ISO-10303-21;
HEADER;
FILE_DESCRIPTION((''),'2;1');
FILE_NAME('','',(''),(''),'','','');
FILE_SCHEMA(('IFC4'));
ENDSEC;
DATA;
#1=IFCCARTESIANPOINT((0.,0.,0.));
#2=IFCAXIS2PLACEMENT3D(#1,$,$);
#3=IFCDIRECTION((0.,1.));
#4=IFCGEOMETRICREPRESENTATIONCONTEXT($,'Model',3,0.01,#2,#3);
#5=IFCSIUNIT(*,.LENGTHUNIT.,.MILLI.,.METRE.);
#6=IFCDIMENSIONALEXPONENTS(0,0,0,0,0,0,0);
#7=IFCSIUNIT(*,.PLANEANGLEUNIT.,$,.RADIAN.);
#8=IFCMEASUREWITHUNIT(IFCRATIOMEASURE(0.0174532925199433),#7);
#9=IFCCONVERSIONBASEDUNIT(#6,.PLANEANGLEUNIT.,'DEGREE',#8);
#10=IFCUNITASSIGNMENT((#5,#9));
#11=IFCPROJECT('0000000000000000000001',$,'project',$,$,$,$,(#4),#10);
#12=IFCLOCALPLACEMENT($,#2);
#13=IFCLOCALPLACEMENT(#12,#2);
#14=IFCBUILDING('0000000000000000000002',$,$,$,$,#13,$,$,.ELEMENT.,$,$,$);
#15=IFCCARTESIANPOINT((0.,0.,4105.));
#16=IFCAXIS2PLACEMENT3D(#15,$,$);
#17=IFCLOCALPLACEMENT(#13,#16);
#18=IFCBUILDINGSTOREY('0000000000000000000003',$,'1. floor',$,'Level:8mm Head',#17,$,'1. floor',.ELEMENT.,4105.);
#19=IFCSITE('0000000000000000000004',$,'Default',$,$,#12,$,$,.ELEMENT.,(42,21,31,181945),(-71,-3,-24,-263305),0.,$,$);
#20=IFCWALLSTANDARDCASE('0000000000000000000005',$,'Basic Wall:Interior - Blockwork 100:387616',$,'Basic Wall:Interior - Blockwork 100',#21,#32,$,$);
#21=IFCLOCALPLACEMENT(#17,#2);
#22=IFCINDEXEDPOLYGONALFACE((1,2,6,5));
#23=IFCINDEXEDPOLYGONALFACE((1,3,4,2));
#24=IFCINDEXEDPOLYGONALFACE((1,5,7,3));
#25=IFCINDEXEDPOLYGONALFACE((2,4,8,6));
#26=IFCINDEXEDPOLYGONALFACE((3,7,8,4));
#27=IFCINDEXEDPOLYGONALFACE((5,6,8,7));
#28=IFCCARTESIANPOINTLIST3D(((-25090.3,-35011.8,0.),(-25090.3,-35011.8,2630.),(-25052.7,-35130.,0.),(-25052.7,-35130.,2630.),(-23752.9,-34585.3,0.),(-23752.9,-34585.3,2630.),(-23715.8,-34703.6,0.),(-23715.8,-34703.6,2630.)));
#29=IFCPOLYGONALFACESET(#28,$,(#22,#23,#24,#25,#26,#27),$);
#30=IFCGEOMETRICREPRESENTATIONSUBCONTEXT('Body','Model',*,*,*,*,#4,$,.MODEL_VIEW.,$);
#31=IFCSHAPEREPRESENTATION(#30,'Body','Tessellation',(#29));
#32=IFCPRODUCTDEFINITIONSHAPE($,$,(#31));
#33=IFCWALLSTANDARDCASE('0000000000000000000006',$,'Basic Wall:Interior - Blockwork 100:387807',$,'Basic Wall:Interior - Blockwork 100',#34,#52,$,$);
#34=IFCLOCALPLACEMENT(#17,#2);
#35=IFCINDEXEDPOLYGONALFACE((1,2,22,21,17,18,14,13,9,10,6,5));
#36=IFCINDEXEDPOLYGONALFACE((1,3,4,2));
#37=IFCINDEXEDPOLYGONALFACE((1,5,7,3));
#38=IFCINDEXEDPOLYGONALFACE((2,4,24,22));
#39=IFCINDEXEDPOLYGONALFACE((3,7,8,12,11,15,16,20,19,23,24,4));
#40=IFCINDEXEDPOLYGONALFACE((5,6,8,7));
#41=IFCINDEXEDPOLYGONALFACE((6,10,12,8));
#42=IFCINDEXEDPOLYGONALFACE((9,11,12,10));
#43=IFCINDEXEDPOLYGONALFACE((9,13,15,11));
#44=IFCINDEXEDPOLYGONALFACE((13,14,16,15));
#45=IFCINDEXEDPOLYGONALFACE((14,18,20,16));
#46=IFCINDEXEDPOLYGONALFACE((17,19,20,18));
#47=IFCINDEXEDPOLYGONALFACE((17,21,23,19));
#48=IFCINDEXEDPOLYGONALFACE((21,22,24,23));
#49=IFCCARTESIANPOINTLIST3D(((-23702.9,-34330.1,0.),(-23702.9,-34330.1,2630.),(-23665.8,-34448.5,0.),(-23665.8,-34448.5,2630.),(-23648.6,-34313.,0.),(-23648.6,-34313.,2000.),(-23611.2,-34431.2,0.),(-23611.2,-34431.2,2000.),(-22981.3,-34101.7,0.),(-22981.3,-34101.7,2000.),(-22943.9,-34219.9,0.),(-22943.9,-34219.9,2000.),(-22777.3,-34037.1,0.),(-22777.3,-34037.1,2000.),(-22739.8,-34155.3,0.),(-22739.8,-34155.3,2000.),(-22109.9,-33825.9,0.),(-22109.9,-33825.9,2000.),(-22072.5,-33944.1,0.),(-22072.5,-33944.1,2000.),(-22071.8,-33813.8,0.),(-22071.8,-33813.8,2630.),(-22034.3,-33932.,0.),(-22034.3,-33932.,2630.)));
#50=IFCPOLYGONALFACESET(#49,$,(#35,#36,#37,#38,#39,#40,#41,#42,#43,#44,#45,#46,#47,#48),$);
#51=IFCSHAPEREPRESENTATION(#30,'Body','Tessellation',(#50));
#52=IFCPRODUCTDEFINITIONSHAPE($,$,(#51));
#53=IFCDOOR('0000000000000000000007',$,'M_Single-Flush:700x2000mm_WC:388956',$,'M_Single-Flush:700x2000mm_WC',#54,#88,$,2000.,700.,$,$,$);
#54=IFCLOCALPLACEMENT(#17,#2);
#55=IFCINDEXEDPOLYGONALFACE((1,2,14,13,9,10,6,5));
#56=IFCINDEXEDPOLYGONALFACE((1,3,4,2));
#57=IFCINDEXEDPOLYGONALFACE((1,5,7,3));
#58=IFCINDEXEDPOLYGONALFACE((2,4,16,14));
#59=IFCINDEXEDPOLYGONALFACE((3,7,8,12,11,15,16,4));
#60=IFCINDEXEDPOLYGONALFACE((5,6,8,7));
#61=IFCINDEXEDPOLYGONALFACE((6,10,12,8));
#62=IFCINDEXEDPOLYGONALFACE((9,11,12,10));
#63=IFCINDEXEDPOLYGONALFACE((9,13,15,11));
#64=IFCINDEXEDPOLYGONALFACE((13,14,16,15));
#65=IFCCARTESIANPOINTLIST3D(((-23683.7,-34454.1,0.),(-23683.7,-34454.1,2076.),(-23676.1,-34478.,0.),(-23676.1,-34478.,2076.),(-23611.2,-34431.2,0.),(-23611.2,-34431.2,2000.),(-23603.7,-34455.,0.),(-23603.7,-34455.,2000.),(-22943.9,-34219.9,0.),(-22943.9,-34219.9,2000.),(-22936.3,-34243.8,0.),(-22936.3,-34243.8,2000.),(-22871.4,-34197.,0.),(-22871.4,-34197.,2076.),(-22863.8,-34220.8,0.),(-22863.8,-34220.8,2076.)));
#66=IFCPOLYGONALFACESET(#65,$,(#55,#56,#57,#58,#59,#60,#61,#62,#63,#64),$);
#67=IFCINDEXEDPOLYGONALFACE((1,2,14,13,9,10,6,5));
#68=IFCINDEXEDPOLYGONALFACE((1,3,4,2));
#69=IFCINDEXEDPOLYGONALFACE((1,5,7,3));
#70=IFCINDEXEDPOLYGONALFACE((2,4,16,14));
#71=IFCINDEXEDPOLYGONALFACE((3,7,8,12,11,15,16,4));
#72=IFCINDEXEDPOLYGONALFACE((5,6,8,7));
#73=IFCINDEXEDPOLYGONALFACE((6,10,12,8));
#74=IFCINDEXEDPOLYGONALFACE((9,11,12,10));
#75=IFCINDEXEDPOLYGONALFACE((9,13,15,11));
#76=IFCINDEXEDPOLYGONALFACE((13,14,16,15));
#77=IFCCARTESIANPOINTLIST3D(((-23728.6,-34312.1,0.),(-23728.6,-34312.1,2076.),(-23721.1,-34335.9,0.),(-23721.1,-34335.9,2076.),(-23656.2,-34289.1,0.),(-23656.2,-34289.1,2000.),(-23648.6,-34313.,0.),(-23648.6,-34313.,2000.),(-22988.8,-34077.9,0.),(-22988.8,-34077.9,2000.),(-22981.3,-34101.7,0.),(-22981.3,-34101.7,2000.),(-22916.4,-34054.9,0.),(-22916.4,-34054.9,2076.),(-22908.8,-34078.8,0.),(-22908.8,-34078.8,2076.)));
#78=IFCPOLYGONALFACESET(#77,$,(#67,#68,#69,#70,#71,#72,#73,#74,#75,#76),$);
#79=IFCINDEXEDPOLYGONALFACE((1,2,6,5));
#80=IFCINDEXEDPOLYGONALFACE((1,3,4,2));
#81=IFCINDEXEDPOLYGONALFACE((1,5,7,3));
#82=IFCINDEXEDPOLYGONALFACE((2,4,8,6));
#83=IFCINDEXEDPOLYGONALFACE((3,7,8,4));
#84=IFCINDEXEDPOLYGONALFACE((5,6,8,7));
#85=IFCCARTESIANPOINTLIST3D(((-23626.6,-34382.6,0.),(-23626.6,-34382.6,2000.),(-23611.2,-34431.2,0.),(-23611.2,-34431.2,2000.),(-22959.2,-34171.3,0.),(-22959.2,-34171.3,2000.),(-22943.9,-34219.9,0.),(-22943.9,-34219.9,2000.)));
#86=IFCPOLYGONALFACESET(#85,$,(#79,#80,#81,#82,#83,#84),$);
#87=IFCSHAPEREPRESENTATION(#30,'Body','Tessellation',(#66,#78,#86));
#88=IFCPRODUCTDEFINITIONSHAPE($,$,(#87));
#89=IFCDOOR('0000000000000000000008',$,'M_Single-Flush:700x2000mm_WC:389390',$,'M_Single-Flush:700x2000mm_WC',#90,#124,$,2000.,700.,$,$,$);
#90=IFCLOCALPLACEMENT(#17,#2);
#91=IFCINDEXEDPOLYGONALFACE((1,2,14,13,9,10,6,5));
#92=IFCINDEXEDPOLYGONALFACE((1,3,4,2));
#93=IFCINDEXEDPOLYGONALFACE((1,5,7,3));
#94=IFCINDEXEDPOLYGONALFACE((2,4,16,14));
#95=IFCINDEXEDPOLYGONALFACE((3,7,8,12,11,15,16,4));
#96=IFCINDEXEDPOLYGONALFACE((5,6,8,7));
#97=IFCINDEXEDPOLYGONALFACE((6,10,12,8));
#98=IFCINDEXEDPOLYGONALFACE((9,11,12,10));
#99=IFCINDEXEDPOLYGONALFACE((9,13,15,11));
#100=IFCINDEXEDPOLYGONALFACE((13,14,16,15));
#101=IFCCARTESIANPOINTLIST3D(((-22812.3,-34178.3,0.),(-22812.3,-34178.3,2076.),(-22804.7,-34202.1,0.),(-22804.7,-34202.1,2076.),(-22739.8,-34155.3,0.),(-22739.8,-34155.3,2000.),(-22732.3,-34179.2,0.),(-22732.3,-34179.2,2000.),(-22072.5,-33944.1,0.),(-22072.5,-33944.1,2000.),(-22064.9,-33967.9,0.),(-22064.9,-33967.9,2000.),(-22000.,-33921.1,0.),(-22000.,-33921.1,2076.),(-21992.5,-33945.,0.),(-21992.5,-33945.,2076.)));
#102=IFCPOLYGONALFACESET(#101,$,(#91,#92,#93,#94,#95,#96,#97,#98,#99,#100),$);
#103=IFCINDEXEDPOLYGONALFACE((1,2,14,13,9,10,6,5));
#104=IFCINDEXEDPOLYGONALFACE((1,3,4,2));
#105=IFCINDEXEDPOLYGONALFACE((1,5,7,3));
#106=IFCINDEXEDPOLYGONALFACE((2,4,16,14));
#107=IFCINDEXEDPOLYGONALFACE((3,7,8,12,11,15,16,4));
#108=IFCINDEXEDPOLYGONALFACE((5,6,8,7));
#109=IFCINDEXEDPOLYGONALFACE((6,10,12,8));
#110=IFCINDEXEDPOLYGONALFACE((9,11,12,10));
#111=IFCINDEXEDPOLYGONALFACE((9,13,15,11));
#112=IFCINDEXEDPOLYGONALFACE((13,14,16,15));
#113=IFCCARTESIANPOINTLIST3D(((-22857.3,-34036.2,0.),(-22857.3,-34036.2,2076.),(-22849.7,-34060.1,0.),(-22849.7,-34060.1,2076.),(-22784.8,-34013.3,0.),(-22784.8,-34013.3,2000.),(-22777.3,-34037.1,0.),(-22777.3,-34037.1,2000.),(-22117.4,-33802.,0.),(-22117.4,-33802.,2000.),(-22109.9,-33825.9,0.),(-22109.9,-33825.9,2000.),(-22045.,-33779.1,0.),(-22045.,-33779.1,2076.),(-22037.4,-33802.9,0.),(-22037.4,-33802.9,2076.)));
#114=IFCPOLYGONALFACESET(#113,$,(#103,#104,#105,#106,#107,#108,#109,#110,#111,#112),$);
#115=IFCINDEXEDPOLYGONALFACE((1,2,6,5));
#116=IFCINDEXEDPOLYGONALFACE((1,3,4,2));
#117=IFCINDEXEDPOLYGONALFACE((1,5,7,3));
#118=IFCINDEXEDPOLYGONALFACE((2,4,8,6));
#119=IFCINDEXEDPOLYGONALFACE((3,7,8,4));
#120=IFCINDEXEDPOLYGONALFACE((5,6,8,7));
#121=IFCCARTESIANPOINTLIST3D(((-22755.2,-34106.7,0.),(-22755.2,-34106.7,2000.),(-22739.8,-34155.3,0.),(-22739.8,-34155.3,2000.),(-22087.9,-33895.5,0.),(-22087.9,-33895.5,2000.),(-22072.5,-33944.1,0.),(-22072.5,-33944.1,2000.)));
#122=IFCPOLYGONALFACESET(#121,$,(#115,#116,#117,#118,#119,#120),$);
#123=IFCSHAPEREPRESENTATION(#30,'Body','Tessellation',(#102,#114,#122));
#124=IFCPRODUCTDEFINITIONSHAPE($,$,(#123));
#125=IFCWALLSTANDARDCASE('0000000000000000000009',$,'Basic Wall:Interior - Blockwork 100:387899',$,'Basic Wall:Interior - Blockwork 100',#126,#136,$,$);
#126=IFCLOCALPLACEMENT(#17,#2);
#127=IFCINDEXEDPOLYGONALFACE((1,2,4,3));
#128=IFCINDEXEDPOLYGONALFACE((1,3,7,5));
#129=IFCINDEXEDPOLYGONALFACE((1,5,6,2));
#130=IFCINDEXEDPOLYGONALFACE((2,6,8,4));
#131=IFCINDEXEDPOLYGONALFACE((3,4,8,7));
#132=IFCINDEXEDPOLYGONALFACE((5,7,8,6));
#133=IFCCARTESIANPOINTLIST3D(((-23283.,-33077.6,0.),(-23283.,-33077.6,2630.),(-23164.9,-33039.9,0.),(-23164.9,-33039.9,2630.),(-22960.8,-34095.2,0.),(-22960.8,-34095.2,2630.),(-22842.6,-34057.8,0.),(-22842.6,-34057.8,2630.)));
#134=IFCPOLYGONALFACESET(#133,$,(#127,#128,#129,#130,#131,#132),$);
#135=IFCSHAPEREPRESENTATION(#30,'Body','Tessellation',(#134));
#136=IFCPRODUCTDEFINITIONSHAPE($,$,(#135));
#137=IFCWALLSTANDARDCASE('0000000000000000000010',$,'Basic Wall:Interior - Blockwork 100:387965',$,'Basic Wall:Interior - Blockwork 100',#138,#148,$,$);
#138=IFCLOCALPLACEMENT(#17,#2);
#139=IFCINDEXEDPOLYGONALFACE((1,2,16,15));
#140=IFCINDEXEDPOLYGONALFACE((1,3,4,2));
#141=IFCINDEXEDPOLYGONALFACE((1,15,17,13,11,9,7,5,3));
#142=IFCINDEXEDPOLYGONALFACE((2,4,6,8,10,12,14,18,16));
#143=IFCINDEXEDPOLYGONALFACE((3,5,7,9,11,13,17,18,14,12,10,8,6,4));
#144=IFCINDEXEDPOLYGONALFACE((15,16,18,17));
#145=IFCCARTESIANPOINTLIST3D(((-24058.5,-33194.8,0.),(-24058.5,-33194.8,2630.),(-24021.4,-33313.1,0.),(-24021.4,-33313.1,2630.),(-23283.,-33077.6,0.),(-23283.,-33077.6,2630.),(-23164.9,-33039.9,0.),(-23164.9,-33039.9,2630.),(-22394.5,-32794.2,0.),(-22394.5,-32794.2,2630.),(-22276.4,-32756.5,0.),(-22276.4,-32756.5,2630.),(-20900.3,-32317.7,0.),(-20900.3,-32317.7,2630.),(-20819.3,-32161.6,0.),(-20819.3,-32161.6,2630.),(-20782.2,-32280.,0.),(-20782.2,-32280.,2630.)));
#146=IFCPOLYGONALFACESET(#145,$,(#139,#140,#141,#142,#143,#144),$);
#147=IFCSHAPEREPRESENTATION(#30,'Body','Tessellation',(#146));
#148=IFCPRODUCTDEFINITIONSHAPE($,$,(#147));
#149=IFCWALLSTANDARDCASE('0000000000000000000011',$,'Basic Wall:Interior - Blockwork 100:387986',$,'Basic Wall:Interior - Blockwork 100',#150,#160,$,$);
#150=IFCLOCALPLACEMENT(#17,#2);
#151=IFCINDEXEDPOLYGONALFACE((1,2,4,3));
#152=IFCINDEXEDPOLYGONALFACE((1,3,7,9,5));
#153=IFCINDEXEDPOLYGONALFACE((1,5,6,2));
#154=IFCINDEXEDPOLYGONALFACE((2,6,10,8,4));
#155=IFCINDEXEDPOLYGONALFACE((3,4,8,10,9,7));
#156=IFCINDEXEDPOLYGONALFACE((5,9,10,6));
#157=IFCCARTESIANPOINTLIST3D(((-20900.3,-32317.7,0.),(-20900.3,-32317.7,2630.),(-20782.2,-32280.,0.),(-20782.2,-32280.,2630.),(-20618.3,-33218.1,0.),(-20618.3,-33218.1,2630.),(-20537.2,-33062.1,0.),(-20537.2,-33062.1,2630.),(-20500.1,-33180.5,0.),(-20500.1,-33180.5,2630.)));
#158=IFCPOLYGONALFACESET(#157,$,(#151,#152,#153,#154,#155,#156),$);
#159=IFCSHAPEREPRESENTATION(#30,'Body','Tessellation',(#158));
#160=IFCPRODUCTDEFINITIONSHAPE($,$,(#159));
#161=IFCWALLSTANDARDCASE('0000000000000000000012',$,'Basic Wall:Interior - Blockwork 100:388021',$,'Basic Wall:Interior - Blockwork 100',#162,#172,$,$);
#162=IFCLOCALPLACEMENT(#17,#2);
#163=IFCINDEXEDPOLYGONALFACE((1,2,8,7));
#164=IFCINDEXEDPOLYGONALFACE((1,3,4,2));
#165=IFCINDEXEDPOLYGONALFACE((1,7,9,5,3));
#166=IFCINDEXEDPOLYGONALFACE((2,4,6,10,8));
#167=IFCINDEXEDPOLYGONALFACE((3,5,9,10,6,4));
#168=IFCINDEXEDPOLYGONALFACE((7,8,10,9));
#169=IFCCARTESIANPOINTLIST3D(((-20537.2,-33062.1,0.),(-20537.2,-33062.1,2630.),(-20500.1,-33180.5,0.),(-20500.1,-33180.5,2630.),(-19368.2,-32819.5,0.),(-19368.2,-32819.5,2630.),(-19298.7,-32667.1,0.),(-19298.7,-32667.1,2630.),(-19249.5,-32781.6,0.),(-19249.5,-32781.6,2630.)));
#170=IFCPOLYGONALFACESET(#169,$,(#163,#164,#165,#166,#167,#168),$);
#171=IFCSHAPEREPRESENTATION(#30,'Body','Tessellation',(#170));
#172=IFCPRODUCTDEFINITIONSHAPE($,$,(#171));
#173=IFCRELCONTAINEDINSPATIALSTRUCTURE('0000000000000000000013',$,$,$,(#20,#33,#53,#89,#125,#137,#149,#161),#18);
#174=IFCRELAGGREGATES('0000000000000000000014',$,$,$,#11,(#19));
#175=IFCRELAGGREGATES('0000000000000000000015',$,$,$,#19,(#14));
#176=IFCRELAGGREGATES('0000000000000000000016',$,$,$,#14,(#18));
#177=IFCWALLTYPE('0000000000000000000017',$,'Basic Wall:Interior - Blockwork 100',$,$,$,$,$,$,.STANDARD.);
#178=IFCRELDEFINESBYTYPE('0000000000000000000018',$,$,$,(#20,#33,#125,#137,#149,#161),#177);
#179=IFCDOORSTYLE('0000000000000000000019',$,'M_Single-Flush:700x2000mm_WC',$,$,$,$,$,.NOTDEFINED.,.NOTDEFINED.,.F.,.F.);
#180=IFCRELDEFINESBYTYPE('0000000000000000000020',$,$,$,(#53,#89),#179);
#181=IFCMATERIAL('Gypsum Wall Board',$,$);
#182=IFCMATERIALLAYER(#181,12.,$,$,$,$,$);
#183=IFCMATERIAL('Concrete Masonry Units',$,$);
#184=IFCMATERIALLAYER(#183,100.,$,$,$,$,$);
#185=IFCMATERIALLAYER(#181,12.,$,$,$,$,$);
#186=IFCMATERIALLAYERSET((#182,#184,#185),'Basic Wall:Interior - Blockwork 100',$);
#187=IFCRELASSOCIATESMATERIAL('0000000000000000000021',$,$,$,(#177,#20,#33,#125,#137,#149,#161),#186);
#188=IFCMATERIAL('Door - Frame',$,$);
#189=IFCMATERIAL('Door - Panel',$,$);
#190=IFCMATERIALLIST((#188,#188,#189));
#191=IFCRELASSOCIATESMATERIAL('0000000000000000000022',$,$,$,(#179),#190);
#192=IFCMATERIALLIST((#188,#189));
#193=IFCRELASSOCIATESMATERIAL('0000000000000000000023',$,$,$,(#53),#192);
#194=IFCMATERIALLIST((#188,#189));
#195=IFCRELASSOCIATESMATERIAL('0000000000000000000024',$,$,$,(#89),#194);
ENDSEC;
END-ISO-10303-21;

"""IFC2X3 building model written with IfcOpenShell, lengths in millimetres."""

from ifc_helpers import new_model, entity, si_unit, converted_unit, direction, frame, frame_2d, origin, origin_2d_with_axis, place, context, subcontext, project, spatial, polyline, rectangle, outline, extrude, source, transform, mapped, material, material_list, layer, layer_set, layer_usage, type_object, type_shapes, element, fill, save


model = new_model("IFC2X3")

# Units and contexts
model_context = context("Model", 3, precision=0.01, world=origin(), true_north=direction((0.0, 1.0)))
body_context = subcontext(model_context, "Body", "Model", "MODEL_VIEW")
ifc_project = project(units=[si_unit("LENGTHUNIT", "METRE", prefix="MILLI"), converted_unit("PLANEANGLEUNIT", "DEGREE", entity("IfcRatioMeasure", 0.0174532925199433), si_unit("PLANEANGLEUNIT", "RADIAN"), dimensions=[0, 0, 0, 0, 0, 0, 0])], contexts=[model_context])

# Site, building, storey
site_placement = place(None, origin())
site = spatial("IfcSite", under=ifc_project, at=site_placement, Name="Default", CompositionType="ELEMENT", RefLatitude=(42, 21, 31, 181945), RefLongitude=(-71, -3, -24, -263305), RefElevation=0.0)
building_placement = place(site_placement, origin())
building = spatial("IfcBuilding", under=site, at=building_placement, CompositionType="ELEMENT")
storey_placement = place(building_placement, frame((0.0, 0.0, 4105.0)))
storey = spatial("IfcBuildingStorey", under=building, at=storey_placement, Name="1. floor", ObjectType="Level:8mm Head", LongName="1. floor", CompositionType="ELEMENT", Elevation=4105.0)

# Shared definitions
ifc_material_1 = material(Name="Gypsum Wall Board")
ifc_layer_1 = layer(ifc_material_1, 12.0)
ifc_material_2 = material(Name="Concrete Masonry Units")
ifc_layer_2 = layer(ifc_material_2, 100.0)
ifc_layer_3 = layer(ifc_material_1, 12.0)
ifc_layer_set = layer_set([ifc_layer_1, ifc_layer_2, ifc_layer_3], Name="Basic Wall:Interior - Blockwork 100")
wall_type = type_object("IfcWallType", Name="Basic Wall:Interior - Blockwork 100", PredefinedType="STANDARD", material=ifc_layer_set)
ifc_material_3 = material(Name="Door - Frame")
ifc_material_4 = material(Name="Door - Panel")
ifc_material_list_1 = material_list([ifc_material_3, ifc_material_3, ifc_material_4])
door_style_1 = type_object("IfcDoorStyle", Name="M_Single-Flush:700x2000mm_WC", ConstructionType="NOTDEFINED", OperationType="NOTDEFINED", ParameterTakesPrecedence=False, Sizeable=False, material=ifc_material_list_1)
shared_shape_1 = source(origin(), body_context, "Body", "SweptSolid", [
    extrude(outline(polyline([(-426.0, -1057.0), (426.0, -1057.0), (426.0, 1019.0), (350.0, 1019.0), (350.0, -981.0), (-350.0, -981.0), (-350.0, 1019.0), (-426.0, 1019.0), (-426.0, -1057.0)])), frame((350.0, 124.0, 1019.0), z_axis=(0.0, 1.0, 0.0), x_axis=(1.0, 0.0, 0.0)), (0.0, 0.0, 1.0), 25.0),
    extrude(outline(polyline([(-1057.0, -426.0), (1019.0, -426.0), (1019.0, -350.0), (-981.0, -350.0), (-981.0, 350.0), (1019.0, 350.0), (1019.0, 426.0), (-1057.0, 426.0), (-1057.0, -426.0)])), frame((350.0, -25.0, 1019.0), z_axis=(0.0, 1.0, 0.0), x_axis=(0.0, 0.0, -1.0)), (0.0, 0.0, 1.0), 25.0),
    extrude(rectangle(XDim=51.0, YDim=700.0, at=origin_2d_with_axis()), frame((350.0, 98.5, 0.0), z_axis=(0.0, 0.0, 1.0), x_axis=(0.0, 1.0, 0.0)), (0.0, 0.0, 1.0), 2000.0),
])
type_shapes(door_style_1, [shared_shape_1])

# Wall
ifc_layer_usage_1 = layer_usage(ifc_layer_set, "AXIS2", "NEGATIVE", 62.0)
wall_1_placement = place(storey_placement, frame((-23734.0, -34644.3, 0.0), z_axis=(0.0, 0.0, 1.0), x_axis=(-0.952718, -0.303856, 0.0)))
element("IfcWallStandardCase", 1, at=wall_1_placement, inside=storey, type_object=wall_type, material=ifc_layer_usage_1, Name="Basic Wall:Interior - Blockwork 100:387616", ObjectType="Basic Wall:Interior - Blockwork 100", context=body_context, shape_type="SweptSolid", body=[
    extrude(outline(polyline([(1403.9, -62.0), (1403.9, 62.0), (0.6, 62.0), (0.0, -62.0), (1403.9, -62.0)])), origin(), (0.0, 0.0, 1.0), 2630.0),
])

# Wall, openings, doors
ifc_layer_usage_2 = layer_usage(ifc_layer_set, "AXIS2", "NEGATIVE", 62.0)
wall_2_placement = place(storey_placement, frame((-23684.5, -34389.4, 0.0), z_axis=(0.0, 0.0, 1.0), x_axis=(0.953372, 0.301797, 0.0)))
wall_2 = element("IfcWallStandardCase", 2, at=wall_2_placement, inside=storey, type_object=wall_type, material=ifc_layer_usage_2, Name="Basic Wall:Interior - Blockwork 100:387807", ObjectType="Basic Wall:Interior - Blockwork 100", context=body_context, shape_type="SweptSolid", body=[
    extrude(outline(polyline([(0.0, -62.0), (1711.2, -62.0), (1711.2, 62.0), (902.7, 62.0), (778.7, 62.0), (0.4, 62.0), (0.0, -62.0)])), origin(), (0.0, 0.0, 1.0), 2630.0),
])
opening_1_placement = place(wall_2_placement, frame((757.2, 62.0, 0.0)))
opening_1 = element("IfcOpeningElement", 3, at=opening_1_placement, cuts=wall_2, ObjectType="Opening", context=body_context, shape_type="SweptSolid", body=[
    extrude(rectangle(XDim=700.0, YDim=2000.0, at=frame_2d((1000.0, 350.0), x_axis=(0.0, 1.0))), frame((0.0, 0.0, 0.0), z_axis=(0.0, -1.0, 0.0), x_axis=(0.0, 0.0, 1.0)), (0.0, 0.0, 1.0), 124.0),
])
opening_2_placement = place(wall_2_placement, frame((1671.2, 62.0, 0.0)))
opening_2 = element("IfcOpeningElement", 4, at=opening_2_placement, cuts=wall_2, ObjectType="Opening", context=body_context, shape_type="SweptSolid", body=[
    extrude(rectangle(XDim=700.0, YDim=2000.0, at=frame_2d((1000.0, 350.0), x_axis=(0.0, 1.0))), frame((0.0, 0.0, 0.0), z_axis=(0.0, -1.0, 0.0), x_axis=(0.0, 0.0, 1.0)), (0.0, 0.0, 1.0), 124.0),
])
ifc_material_list_2 = material_list([ifc_material_3, ifc_material_4])
door_1_placement = place(opening_1_placement, frame((0.0, 0.0, 0.0), z_axis=(0.0, 0.0, 1.0), x_axis=(-1.0, 0.0, 0.0)))
door_1 = element("IfcDoor", 5, at=door_1_placement, inside=storey, type_object=door_style_1, material=ifc_material_list_2, Name="M_Single-Flush:700x2000mm_WC:388956", ObjectType="M_Single-Flush:700x2000mm_WC", OverallHeight=2000.0, OverallWidth=700.0, context=body_context, shape_type="MappedRepresentation", body=[
    mapped(shared_shape_1, transform((0.0, 0.0, 0.0), scale=1.0)),
])
fill(opening_1, door_1)
ifc_material_list_3 = material_list([ifc_material_3, ifc_material_4])
door_2_placement = place(opening_2_placement, frame((0.0, 0.0, 0.0), z_axis=(0.0, 0.0, 1.0), x_axis=(-1.0, 0.0, 0.0)))
door_2 = element("IfcDoor", 6, at=door_2_placement, inside=storey, type_object=door_style_1, material=ifc_material_list_3, Name="M_Single-Flush:700x2000mm_WC:389390", ObjectType="M_Single-Flush:700x2000mm_WC", OverallHeight=2000.0, OverallWidth=700.0, context=body_context, shape_type="MappedRepresentation", body=[
    mapped(shared_shape_1, transform((0.0, 0.0, 0.0), scale=1.0)),
])
fill(opening_2, door_2)

# Walls
ifc_layer_usage_3 = layer_usage(ifc_layer_set, "AXIS2", "NEGATIVE", 62.0)
wall_3_placement = place(storey_placement, frame((-23224.0, -33058.6, 0.0), z_axis=(0.0, 0.0, 1.0), x_axis=(0.301797, -0.953372, 0.0)))
element("IfcWallStandardCase", 7, at=wall_3_placement, inside=storey, type_object=wall_type, material=ifc_layer_usage_3, Name="Basic Wall:Interior - Blockwork 100:387899", ObjectType="Basic Wall:Interior - Blockwork 100", context=body_context, shape_type="SweptSolid", body=[
    extrude(outline(polyline([(1067.7, -62.0), (1067.7, 62.0), (0.0, 62.0), (0.3, -62.0), (1067.7, -62.0)])), origin(), (0.0, 0.0, 1.0), 2630.0),
])
ifc_layer_usage_4 = layer_usage(ifc_layer_set, "AXIS2", "NEGATIVE", 62.0)
wall_4_placement = place(storey_placement, frame((-24040.3, -33254.0, 0.0), z_axis=(0.0, 0.0, 1.0), x_axis=(0.952718, 0.303856, 0.0)))
element("IfcWallStandardCase", 8, at=wall_4_placement, inside=storey, type_object=wall_type, material=ifc_layer_usage_4, Name="Basic Wall:Interior - Blockwork 100:387965", ObjectType="Basic Wall:Interior - Blockwork 100", context=body_context, shape_type="SweptSolid", body=[
    extrude(outline(polyline([(3400.0, -62.0), (3400.6, 62.0), (0.6, 62.0), (0.0, -62.0), (775.1, -62.0), (899.1, -62.0), (1707.7, -62.0), (1831.7, -62.0), (3276.0, -62.0), (3400.0, -62.0)])), origin(), (0.0, 0.0, 1.0), 2630.0),
])
ifc_layer_usage_5 = layer_usage(ifc_layer_set, "AXIS2", "NEGATIVE", 62.0)
wall_5_placement = place(storey_placement, frame((-20841.4, -32298.5, 0.0), z_axis=(0.0, 0.0, 1.0), x_axis=(0.298924, -0.954277, 0.0)))
element("IfcWallStandardCase", 9, at=wall_5_placement, inside=storey, type_object=wall_type, material=ifc_layer_usage_5, Name="Basic Wall:Interior - Blockwork 100:387986", ObjectType="Basic Wall:Interior - Blockwork 100", context=body_context, shape_type="SweptSolid", body=[
    extrude(outline(polyline([(944.3, -62.0), (943.6, 62.0), (819.6, 62.0), (0.0, 62.0), (0.6, -62.0), (944.3, -62.0)])), origin(), (0.0, 0.0, 1.0), 2630.0),
])
ifc_layer_usage_6 = layer_usage(ifc_layer_set, "AXIS2", "NEGATIVE", 62.0)
wall_6_placement = place(storey_placement, frame((-20519.0, -33121.4, 0.0), z_axis=(0.0, 0.0, 1.0), x_axis=(0.952718, 0.303856, 0.0)))
element("IfcWallStandardCase", 10, at=wall_6_placement, inside=storey, type_object=wall_type, material=ifc_layer_usage_6, Name="Basic Wall:Interior - Blockwork 100:388021", ObjectType="Basic Wall:Interior - Blockwork 100", context=body_context, shape_type="SweptSolid", body=[
    extrude(outline(polyline([(1312.6, -62.0), (1300.6, 62.0), (0.6, 62.0), (0.0, -62.0), (1188.1, -62.0), (1312.6, -62.0)])), origin(), (0.0, 0.0, 1.0), 2630.0),
])

save(model, "model.ifc")
